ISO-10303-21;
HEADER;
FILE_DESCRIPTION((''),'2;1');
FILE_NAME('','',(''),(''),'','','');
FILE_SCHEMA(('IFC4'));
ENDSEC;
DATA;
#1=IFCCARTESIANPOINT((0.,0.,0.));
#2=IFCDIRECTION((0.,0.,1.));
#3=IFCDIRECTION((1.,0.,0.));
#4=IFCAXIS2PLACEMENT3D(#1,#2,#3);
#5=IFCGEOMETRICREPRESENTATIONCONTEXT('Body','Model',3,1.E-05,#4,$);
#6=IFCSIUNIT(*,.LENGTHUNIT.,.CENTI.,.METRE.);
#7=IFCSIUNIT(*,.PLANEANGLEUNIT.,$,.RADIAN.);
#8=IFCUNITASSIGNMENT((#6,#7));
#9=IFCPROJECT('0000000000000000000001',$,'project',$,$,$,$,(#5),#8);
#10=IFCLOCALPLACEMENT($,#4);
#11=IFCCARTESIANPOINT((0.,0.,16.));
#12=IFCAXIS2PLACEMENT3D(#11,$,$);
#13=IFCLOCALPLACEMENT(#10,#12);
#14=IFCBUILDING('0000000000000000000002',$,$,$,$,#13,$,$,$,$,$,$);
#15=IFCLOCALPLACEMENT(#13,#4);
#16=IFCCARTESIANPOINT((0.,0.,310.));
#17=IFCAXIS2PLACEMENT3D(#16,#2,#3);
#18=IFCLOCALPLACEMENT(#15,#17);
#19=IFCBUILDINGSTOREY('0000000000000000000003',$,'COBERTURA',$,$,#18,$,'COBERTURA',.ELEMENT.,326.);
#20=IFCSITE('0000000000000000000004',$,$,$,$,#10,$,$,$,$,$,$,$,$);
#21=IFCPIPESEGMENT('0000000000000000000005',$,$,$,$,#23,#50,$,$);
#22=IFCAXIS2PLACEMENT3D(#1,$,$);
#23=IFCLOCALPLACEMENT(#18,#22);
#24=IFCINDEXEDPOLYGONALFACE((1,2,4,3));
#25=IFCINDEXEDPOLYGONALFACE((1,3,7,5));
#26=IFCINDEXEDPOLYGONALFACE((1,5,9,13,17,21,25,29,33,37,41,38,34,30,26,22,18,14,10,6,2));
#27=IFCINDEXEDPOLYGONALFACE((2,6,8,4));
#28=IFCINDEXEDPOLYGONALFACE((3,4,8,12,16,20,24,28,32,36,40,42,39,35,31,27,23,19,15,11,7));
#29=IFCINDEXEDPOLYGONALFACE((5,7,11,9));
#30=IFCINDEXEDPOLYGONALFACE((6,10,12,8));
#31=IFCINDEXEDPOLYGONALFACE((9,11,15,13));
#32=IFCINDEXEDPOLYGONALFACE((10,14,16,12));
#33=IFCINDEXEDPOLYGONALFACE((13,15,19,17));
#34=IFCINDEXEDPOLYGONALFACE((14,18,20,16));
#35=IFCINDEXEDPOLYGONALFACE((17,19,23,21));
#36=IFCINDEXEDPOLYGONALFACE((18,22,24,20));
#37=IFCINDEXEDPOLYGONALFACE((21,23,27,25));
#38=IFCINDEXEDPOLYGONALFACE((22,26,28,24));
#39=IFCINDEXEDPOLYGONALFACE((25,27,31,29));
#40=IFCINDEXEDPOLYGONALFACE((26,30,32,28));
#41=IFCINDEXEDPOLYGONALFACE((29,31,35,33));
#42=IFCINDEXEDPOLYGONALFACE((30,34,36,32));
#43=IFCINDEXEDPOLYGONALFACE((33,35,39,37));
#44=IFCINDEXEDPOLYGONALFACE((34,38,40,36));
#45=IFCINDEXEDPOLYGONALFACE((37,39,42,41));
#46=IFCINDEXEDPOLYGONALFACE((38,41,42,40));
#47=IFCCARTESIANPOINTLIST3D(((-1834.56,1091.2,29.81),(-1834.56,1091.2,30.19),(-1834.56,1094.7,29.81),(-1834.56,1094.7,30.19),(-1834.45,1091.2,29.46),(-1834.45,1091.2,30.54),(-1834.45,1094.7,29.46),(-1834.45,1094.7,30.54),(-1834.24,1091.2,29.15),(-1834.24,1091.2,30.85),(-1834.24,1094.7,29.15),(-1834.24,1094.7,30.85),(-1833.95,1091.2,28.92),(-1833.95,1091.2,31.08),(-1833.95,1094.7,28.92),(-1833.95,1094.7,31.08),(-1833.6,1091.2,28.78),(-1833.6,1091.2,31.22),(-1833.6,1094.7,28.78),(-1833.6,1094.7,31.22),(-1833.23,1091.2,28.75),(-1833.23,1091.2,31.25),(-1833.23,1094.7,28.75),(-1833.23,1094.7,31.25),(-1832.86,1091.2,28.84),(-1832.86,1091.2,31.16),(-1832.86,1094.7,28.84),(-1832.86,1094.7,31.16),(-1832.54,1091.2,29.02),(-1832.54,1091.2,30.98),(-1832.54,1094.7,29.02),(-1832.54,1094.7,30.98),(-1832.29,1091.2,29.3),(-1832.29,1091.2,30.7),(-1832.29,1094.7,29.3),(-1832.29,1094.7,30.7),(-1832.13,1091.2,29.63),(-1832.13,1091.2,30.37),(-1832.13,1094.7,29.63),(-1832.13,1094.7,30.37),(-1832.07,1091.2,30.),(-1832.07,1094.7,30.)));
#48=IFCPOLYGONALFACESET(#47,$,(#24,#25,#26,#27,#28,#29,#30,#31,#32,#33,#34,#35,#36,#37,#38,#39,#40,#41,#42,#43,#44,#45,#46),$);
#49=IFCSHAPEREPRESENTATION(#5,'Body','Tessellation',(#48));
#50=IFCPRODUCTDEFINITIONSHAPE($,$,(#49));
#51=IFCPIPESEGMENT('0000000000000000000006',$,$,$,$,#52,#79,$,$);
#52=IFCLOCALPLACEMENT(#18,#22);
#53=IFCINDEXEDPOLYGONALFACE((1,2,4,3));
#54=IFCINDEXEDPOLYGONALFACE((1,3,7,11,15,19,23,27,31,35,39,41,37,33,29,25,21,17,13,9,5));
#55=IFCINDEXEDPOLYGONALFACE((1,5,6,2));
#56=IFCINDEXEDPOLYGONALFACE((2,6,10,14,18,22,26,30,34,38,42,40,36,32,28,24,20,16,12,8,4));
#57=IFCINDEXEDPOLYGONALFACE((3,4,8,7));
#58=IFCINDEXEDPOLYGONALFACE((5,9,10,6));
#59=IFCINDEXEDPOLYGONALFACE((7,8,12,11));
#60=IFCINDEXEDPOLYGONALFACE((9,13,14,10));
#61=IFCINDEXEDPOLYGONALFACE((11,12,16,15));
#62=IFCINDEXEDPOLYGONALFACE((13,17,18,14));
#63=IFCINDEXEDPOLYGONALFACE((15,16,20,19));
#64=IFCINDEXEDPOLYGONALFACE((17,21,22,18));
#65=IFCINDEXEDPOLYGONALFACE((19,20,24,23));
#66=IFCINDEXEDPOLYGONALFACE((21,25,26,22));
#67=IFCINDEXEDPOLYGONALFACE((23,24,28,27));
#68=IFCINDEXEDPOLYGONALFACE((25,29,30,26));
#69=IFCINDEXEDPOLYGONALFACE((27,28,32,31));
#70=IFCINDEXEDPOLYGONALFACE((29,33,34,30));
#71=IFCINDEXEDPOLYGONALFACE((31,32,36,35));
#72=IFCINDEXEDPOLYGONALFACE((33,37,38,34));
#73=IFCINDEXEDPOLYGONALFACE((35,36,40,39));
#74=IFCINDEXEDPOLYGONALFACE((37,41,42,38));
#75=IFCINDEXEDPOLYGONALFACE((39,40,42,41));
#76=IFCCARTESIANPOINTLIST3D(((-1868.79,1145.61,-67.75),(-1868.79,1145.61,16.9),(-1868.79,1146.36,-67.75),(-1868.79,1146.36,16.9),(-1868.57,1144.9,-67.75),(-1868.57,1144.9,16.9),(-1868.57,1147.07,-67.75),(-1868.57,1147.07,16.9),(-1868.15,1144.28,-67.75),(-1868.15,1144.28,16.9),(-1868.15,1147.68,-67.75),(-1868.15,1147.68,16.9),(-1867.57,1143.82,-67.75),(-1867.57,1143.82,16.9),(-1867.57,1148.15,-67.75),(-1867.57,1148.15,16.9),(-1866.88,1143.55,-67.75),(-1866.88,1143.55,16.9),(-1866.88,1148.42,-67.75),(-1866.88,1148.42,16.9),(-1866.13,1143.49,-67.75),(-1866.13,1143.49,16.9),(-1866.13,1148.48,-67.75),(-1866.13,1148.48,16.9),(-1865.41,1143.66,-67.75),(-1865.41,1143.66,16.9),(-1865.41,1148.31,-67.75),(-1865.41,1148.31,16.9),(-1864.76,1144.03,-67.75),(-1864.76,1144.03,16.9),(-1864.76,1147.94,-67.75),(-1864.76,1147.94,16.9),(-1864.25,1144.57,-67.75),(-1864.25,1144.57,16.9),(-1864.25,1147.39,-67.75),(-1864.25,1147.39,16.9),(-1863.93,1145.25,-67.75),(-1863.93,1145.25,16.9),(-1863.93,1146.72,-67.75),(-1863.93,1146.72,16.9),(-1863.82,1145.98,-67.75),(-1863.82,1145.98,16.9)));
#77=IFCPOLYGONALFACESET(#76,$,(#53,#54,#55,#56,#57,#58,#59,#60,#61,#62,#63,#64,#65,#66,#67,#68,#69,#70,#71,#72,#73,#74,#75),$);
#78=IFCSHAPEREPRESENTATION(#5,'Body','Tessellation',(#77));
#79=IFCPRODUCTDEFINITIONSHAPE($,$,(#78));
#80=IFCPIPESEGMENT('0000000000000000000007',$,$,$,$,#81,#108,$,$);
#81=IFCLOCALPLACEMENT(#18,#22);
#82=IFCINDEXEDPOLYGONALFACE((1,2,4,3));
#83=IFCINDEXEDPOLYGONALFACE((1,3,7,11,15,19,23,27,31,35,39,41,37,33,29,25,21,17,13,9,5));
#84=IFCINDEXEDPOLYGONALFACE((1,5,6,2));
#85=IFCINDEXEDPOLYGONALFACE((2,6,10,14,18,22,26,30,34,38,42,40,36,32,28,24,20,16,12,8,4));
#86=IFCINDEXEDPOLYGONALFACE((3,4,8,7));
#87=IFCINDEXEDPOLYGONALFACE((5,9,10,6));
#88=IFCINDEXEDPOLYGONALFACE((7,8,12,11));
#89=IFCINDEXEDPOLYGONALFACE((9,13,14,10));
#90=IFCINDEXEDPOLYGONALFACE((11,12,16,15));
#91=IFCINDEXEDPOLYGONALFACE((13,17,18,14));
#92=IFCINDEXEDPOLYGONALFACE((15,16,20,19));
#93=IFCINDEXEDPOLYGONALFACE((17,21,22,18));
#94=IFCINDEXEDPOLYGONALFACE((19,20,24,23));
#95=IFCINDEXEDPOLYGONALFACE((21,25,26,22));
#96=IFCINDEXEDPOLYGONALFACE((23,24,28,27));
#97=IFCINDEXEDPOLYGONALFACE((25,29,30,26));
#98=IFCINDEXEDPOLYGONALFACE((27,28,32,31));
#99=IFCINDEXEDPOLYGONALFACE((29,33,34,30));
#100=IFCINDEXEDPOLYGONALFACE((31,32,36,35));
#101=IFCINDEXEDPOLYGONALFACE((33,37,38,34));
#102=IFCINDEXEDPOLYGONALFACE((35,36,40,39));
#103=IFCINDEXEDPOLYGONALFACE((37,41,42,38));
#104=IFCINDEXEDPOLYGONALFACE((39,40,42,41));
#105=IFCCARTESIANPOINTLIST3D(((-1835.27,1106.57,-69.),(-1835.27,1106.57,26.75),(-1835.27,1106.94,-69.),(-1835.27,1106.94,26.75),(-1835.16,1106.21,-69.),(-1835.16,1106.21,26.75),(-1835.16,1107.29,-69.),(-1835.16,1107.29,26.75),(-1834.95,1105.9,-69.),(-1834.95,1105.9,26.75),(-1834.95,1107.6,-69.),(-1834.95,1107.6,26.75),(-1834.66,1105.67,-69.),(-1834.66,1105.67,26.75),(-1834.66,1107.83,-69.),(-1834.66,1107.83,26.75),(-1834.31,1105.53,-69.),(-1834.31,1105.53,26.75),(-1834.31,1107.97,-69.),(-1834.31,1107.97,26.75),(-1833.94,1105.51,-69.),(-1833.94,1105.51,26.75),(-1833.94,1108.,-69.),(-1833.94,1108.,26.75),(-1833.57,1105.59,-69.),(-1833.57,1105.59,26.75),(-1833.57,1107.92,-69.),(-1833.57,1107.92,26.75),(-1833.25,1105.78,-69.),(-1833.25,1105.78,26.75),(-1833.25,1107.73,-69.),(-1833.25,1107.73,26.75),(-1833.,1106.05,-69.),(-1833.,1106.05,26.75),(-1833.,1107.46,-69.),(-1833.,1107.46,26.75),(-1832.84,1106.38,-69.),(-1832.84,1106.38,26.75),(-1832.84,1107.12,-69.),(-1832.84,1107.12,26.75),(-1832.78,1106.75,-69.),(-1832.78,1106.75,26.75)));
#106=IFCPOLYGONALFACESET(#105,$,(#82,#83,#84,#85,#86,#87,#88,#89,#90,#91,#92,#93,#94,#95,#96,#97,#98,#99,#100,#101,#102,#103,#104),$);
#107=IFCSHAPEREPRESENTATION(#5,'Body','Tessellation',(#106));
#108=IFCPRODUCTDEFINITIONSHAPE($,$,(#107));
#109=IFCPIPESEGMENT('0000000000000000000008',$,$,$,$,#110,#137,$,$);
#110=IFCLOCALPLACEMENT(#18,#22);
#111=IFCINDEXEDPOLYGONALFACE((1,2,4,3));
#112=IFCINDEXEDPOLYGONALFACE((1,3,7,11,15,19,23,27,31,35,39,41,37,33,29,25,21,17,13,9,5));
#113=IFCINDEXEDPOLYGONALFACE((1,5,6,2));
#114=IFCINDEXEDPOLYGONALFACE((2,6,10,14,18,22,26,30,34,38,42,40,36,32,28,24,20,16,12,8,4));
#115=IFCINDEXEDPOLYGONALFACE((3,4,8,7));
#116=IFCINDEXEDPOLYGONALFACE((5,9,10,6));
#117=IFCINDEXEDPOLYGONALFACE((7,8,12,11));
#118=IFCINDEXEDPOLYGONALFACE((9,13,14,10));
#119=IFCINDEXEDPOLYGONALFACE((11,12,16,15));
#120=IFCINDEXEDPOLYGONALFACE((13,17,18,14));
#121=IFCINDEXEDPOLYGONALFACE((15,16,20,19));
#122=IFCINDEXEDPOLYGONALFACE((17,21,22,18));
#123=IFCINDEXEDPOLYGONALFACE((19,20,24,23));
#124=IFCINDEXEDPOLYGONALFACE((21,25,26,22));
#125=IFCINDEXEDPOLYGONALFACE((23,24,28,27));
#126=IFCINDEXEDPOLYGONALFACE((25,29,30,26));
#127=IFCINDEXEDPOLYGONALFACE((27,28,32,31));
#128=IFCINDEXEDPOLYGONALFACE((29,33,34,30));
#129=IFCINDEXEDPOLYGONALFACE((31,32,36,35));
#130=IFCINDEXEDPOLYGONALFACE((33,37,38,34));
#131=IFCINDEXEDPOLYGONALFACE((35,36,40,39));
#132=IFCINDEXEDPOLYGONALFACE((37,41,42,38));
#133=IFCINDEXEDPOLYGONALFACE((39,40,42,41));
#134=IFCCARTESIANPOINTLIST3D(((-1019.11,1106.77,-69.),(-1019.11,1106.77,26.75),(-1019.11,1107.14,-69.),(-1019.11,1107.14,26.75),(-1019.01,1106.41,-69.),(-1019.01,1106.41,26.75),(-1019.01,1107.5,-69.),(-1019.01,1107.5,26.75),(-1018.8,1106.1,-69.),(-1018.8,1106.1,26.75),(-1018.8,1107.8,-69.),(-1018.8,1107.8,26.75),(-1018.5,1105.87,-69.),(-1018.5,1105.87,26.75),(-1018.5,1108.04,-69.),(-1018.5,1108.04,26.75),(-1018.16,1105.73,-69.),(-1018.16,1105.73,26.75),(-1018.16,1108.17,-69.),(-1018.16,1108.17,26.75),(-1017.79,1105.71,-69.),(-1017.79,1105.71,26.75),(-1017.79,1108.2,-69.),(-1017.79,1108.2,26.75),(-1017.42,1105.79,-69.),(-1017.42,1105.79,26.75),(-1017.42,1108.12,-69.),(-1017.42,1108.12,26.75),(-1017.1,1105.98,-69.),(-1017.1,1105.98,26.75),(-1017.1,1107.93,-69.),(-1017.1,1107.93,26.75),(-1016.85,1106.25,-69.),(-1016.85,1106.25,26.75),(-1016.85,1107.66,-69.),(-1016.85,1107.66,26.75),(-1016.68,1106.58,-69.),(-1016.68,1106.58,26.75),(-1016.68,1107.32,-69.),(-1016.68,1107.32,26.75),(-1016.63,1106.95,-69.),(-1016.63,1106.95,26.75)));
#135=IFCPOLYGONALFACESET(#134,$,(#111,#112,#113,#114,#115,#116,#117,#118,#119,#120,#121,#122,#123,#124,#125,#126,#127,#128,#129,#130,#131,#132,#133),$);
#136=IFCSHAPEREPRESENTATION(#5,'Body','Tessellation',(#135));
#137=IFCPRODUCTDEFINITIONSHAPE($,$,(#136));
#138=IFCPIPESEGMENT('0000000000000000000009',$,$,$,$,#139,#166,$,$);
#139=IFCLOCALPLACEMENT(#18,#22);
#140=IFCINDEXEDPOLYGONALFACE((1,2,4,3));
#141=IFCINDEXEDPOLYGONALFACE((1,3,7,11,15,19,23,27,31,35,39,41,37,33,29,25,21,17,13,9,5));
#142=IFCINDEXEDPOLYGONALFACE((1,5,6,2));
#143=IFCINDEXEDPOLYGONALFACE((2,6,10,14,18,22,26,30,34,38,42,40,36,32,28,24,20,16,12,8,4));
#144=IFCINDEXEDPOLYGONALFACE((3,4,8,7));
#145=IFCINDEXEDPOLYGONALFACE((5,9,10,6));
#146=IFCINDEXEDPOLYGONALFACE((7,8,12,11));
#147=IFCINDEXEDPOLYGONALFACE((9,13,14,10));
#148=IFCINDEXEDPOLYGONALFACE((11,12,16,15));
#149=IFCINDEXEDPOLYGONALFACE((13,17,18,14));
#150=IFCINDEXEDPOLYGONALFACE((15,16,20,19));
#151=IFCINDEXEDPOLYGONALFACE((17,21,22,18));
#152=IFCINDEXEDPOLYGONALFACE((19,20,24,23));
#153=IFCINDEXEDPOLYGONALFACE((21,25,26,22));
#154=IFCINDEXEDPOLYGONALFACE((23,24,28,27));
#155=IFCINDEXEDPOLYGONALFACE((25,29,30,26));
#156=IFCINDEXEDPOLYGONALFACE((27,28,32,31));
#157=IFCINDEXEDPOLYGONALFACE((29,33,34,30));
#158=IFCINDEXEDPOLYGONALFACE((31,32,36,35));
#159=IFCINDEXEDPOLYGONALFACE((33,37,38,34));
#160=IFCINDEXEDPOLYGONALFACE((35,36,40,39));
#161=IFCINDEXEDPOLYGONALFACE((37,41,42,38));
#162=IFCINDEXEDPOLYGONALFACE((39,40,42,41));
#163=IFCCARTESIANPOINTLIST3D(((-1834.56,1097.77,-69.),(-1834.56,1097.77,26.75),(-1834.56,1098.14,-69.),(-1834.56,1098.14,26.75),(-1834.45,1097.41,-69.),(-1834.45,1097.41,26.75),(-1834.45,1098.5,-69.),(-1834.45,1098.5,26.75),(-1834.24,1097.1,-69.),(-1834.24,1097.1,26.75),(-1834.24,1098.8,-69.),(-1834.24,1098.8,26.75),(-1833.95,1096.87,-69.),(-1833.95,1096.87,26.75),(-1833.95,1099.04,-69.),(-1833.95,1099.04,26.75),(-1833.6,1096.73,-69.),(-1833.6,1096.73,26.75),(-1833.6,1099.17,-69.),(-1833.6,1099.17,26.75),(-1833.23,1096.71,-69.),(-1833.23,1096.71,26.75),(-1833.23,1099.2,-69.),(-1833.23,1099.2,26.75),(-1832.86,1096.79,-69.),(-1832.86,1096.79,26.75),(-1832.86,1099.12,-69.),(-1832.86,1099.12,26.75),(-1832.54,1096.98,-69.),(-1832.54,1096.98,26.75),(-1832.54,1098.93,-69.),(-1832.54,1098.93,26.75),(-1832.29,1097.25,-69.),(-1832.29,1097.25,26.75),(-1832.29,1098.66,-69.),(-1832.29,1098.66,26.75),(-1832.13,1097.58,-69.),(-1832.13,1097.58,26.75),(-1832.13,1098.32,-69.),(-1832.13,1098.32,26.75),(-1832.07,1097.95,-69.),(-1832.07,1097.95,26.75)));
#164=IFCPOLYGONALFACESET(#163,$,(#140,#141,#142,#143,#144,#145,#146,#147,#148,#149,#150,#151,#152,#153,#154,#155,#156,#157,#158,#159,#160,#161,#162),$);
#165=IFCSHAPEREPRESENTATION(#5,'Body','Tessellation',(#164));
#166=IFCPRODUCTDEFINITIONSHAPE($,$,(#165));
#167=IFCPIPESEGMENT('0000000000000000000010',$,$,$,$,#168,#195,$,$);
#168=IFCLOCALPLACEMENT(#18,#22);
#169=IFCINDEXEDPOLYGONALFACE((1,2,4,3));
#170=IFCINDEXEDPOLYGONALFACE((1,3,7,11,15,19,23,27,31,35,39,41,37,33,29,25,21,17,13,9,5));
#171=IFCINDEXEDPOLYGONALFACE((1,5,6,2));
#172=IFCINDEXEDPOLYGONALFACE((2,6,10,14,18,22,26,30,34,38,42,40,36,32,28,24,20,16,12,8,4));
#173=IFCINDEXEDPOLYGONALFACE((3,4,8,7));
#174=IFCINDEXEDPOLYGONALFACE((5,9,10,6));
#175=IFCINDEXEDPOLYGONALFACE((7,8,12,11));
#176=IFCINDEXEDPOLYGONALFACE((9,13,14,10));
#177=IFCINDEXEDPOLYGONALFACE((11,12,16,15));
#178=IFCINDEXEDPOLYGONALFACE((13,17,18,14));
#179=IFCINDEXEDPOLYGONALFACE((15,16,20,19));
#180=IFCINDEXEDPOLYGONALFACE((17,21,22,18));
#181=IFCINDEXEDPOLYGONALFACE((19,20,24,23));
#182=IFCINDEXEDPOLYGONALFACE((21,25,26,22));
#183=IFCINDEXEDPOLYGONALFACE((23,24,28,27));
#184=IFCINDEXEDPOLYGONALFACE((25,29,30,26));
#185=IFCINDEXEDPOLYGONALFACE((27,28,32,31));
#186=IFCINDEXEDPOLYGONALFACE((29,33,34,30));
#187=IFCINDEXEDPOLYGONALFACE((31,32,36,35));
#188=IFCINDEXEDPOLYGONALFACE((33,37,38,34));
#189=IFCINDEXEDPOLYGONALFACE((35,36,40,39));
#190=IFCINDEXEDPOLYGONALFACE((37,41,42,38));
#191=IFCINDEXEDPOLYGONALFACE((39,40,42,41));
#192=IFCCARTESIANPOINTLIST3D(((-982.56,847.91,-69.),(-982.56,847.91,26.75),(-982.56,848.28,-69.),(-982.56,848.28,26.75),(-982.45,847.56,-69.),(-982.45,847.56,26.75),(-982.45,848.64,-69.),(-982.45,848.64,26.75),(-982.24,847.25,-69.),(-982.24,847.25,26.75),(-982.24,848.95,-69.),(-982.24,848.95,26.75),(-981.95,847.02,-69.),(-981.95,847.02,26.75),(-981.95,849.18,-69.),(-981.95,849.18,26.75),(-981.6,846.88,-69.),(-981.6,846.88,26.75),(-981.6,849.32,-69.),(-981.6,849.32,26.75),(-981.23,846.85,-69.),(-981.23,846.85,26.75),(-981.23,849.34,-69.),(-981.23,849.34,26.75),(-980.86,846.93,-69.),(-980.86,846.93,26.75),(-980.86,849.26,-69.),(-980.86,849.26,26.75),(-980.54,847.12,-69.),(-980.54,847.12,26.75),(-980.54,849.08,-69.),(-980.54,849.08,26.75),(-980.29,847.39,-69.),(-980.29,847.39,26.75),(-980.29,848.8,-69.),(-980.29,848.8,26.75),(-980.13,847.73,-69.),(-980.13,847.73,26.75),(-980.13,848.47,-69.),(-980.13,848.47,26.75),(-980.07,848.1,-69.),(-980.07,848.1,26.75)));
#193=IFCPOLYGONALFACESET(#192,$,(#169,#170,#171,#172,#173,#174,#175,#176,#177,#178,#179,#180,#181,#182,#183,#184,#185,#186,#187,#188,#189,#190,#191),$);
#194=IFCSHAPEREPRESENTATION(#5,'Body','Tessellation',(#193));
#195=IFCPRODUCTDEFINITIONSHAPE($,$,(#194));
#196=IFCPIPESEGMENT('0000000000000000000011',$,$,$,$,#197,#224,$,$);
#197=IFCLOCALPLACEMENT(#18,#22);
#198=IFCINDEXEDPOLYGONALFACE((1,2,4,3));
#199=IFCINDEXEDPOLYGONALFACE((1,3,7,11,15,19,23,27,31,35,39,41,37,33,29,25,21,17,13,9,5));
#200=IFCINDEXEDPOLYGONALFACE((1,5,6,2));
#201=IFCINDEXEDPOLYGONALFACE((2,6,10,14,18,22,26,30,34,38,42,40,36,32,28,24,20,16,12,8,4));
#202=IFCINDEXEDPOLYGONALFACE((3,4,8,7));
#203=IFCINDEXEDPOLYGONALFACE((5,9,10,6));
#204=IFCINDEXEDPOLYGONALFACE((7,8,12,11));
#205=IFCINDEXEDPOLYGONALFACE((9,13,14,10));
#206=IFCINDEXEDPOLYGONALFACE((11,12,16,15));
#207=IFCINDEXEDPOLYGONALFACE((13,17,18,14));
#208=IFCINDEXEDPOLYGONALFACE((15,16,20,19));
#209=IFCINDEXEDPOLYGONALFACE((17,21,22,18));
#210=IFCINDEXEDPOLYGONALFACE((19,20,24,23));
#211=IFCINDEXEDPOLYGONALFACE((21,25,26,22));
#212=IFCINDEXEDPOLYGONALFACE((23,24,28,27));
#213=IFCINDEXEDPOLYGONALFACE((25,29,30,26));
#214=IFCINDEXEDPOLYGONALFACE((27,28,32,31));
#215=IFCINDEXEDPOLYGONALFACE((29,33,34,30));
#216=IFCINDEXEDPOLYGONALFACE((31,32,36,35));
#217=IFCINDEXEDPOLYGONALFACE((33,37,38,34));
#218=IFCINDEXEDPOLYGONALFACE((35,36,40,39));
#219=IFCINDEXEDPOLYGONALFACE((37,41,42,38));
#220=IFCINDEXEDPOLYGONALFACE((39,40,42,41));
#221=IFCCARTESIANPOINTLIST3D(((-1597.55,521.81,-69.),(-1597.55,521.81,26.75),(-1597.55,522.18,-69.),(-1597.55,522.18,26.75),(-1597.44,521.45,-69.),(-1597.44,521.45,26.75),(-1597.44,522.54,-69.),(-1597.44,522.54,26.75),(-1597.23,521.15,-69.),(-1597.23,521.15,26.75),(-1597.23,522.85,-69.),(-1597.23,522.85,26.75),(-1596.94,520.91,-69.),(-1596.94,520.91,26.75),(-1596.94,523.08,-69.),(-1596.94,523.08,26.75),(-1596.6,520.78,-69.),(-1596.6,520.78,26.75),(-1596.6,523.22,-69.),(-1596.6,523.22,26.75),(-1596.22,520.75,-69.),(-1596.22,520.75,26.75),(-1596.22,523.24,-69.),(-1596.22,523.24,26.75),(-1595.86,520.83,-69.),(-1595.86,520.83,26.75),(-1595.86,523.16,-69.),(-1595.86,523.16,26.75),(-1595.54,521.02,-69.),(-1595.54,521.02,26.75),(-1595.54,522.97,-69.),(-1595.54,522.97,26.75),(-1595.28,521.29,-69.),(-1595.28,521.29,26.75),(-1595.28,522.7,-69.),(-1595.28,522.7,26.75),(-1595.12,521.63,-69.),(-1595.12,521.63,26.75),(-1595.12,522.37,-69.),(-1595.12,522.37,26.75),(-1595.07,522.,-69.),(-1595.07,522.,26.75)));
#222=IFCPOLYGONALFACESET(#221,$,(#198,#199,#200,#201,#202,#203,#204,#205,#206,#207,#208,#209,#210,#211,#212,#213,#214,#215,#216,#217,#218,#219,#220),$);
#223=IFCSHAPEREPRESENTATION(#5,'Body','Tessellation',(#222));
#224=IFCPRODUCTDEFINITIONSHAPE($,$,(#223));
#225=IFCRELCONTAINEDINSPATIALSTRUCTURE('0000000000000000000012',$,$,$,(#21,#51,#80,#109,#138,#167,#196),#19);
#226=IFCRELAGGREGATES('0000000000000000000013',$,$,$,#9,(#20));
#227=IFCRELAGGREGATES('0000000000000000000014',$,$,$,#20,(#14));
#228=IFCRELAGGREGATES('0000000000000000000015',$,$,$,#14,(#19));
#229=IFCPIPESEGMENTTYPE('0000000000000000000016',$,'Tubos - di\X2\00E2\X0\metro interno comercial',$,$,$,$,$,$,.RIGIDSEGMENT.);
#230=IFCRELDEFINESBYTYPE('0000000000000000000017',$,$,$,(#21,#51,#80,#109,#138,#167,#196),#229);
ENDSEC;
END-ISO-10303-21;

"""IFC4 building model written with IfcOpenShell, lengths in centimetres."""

from ifc_helpers import new_model, si_unit, frame, origin_with_axes, origin_2d_with_axis, place, context, project, spatial, circle, extrude, type_object, element, save


model = new_model("IFC4")

# Units and contexts
model_context = context("Model", 3, precision=1e-05, world=origin_with_axes(), identifier="Body")
ifc_project = project(units=[si_unit("LENGTHUNIT", "METRE", prefix="CENTI"), si_unit("PLANEANGLEUNIT", "RADIAN")], contexts=[model_context])

# Site, building, storey
site_placement = place(None, origin_with_axes())
site = spatial("IfcSite", under=ifc_project, at=site_placement)
building_placement = place(site_placement, frame((0.0, 0.0, 16.0)))
building = spatial("IfcBuilding", under=site, at=building_placement)
placement = place(building_placement, origin_with_axes())
storey_placement = place(placement, frame((0.0, 0.0, 310.0), z_axis=(0.0, 0.0, 1.0), x_axis=(1.0, 0.0, 0.0)))
storey = spatial("IfcBuildingStorey", under=building, at=storey_placement, Name="COBERTURA", LongName="COBERTURA", CompositionType="ELEMENT", Elevation=326.0)

# Pipe segments
pipe_segment_type = type_object("IfcPipeSegmentType", Name="Tubos - diâmetro interno comercial", PredefinedType="RIGIDSEGMENT")
pipe_segment_1_placement = place(storey_placement, frame((-1833.32, 1092.95, 31.25), z_axis=(0.0, 0.0, 1.0), x_axis=(1.0, 0.0, 0.0)))
element("IfcPipeSegment", 1, at=pipe_segment_1_placement, inside=storey, type_object=pipe_segment_type, context=model_context, shape_type="SolidModel", body=[
    extrude(circle(Radius=1.25, at=origin_2d_with_axis()), frame((0.0, -1.75, -1.25), z_axis=(0.0, 1.0, 0.0), x_axis=(1.0, 0.0, 0.0)), (0.0, 0.0, 1.0), 3.5),
])
pipe_segment_2_placement = place(storey_placement, frame((-1866.32, 1145.98, 16.9), z_axis=(0.0, 0.0, 1.0), x_axis=(1.0, 0.0, 0.0)))
element("IfcPipeSegment", 2, at=pipe_segment_2_placement, inside=storey, type_object=pipe_segment_type, context=model_context, shape_type="SolidModel", body=[
    extrude(circle(Radius=2.5, at=origin_2d_with_axis()), frame((0.0, 0.0, 0.0), z_axis=(0.0, 0.0, -1.0), x_axis=(1.0, 0.0, 0.0)), (0.0, 0.0, 1.0), 84.65),
])
for number, where, z_axis, x_axis in (
    (3, (-1834.03, 1106.75, 26.75), (0.0, 0.0, 1.0), (1.0, 0.0, 0.0)),
    (4, (-1017.88, 1106.95, 26.75), (0.0, 0.0, 1.0), (1.0, 0.0, 0.0)),
    (5, (-1833.32, 1097.95, 26.75), (0.0, 0.0, 1.0), (1.0, 0.0, 0.0)),
    (6, (-981.32, 848.1, 26.75), (0.0, 0.0, 1.0), (1.0, 0.0, 0.0)),
    (7, (-1596.32, 522.0, 26.75), (0.0, 0.0, 1.0), (1.0, 0.0, 0.0)),
):
    element("IfcPipeSegment", number, at=place(storey_placement, frame(where, z_axis=z_axis, x_axis=x_axis)), inside=storey, type_object=pipe_segment_type, context=model_context, shape_type="SolidModel", body=[
        extrude(circle(Radius=1.25, at=origin_2d_with_axis()), frame((0.0, 0.0, 0.0), z_axis=(0.0, 0.0, -1.0), x_axis=(1.0, 0.0, 0.0)), (0.0, 0.0, 1.0), 95.75),
    ])

save(model, "model.ifc")
